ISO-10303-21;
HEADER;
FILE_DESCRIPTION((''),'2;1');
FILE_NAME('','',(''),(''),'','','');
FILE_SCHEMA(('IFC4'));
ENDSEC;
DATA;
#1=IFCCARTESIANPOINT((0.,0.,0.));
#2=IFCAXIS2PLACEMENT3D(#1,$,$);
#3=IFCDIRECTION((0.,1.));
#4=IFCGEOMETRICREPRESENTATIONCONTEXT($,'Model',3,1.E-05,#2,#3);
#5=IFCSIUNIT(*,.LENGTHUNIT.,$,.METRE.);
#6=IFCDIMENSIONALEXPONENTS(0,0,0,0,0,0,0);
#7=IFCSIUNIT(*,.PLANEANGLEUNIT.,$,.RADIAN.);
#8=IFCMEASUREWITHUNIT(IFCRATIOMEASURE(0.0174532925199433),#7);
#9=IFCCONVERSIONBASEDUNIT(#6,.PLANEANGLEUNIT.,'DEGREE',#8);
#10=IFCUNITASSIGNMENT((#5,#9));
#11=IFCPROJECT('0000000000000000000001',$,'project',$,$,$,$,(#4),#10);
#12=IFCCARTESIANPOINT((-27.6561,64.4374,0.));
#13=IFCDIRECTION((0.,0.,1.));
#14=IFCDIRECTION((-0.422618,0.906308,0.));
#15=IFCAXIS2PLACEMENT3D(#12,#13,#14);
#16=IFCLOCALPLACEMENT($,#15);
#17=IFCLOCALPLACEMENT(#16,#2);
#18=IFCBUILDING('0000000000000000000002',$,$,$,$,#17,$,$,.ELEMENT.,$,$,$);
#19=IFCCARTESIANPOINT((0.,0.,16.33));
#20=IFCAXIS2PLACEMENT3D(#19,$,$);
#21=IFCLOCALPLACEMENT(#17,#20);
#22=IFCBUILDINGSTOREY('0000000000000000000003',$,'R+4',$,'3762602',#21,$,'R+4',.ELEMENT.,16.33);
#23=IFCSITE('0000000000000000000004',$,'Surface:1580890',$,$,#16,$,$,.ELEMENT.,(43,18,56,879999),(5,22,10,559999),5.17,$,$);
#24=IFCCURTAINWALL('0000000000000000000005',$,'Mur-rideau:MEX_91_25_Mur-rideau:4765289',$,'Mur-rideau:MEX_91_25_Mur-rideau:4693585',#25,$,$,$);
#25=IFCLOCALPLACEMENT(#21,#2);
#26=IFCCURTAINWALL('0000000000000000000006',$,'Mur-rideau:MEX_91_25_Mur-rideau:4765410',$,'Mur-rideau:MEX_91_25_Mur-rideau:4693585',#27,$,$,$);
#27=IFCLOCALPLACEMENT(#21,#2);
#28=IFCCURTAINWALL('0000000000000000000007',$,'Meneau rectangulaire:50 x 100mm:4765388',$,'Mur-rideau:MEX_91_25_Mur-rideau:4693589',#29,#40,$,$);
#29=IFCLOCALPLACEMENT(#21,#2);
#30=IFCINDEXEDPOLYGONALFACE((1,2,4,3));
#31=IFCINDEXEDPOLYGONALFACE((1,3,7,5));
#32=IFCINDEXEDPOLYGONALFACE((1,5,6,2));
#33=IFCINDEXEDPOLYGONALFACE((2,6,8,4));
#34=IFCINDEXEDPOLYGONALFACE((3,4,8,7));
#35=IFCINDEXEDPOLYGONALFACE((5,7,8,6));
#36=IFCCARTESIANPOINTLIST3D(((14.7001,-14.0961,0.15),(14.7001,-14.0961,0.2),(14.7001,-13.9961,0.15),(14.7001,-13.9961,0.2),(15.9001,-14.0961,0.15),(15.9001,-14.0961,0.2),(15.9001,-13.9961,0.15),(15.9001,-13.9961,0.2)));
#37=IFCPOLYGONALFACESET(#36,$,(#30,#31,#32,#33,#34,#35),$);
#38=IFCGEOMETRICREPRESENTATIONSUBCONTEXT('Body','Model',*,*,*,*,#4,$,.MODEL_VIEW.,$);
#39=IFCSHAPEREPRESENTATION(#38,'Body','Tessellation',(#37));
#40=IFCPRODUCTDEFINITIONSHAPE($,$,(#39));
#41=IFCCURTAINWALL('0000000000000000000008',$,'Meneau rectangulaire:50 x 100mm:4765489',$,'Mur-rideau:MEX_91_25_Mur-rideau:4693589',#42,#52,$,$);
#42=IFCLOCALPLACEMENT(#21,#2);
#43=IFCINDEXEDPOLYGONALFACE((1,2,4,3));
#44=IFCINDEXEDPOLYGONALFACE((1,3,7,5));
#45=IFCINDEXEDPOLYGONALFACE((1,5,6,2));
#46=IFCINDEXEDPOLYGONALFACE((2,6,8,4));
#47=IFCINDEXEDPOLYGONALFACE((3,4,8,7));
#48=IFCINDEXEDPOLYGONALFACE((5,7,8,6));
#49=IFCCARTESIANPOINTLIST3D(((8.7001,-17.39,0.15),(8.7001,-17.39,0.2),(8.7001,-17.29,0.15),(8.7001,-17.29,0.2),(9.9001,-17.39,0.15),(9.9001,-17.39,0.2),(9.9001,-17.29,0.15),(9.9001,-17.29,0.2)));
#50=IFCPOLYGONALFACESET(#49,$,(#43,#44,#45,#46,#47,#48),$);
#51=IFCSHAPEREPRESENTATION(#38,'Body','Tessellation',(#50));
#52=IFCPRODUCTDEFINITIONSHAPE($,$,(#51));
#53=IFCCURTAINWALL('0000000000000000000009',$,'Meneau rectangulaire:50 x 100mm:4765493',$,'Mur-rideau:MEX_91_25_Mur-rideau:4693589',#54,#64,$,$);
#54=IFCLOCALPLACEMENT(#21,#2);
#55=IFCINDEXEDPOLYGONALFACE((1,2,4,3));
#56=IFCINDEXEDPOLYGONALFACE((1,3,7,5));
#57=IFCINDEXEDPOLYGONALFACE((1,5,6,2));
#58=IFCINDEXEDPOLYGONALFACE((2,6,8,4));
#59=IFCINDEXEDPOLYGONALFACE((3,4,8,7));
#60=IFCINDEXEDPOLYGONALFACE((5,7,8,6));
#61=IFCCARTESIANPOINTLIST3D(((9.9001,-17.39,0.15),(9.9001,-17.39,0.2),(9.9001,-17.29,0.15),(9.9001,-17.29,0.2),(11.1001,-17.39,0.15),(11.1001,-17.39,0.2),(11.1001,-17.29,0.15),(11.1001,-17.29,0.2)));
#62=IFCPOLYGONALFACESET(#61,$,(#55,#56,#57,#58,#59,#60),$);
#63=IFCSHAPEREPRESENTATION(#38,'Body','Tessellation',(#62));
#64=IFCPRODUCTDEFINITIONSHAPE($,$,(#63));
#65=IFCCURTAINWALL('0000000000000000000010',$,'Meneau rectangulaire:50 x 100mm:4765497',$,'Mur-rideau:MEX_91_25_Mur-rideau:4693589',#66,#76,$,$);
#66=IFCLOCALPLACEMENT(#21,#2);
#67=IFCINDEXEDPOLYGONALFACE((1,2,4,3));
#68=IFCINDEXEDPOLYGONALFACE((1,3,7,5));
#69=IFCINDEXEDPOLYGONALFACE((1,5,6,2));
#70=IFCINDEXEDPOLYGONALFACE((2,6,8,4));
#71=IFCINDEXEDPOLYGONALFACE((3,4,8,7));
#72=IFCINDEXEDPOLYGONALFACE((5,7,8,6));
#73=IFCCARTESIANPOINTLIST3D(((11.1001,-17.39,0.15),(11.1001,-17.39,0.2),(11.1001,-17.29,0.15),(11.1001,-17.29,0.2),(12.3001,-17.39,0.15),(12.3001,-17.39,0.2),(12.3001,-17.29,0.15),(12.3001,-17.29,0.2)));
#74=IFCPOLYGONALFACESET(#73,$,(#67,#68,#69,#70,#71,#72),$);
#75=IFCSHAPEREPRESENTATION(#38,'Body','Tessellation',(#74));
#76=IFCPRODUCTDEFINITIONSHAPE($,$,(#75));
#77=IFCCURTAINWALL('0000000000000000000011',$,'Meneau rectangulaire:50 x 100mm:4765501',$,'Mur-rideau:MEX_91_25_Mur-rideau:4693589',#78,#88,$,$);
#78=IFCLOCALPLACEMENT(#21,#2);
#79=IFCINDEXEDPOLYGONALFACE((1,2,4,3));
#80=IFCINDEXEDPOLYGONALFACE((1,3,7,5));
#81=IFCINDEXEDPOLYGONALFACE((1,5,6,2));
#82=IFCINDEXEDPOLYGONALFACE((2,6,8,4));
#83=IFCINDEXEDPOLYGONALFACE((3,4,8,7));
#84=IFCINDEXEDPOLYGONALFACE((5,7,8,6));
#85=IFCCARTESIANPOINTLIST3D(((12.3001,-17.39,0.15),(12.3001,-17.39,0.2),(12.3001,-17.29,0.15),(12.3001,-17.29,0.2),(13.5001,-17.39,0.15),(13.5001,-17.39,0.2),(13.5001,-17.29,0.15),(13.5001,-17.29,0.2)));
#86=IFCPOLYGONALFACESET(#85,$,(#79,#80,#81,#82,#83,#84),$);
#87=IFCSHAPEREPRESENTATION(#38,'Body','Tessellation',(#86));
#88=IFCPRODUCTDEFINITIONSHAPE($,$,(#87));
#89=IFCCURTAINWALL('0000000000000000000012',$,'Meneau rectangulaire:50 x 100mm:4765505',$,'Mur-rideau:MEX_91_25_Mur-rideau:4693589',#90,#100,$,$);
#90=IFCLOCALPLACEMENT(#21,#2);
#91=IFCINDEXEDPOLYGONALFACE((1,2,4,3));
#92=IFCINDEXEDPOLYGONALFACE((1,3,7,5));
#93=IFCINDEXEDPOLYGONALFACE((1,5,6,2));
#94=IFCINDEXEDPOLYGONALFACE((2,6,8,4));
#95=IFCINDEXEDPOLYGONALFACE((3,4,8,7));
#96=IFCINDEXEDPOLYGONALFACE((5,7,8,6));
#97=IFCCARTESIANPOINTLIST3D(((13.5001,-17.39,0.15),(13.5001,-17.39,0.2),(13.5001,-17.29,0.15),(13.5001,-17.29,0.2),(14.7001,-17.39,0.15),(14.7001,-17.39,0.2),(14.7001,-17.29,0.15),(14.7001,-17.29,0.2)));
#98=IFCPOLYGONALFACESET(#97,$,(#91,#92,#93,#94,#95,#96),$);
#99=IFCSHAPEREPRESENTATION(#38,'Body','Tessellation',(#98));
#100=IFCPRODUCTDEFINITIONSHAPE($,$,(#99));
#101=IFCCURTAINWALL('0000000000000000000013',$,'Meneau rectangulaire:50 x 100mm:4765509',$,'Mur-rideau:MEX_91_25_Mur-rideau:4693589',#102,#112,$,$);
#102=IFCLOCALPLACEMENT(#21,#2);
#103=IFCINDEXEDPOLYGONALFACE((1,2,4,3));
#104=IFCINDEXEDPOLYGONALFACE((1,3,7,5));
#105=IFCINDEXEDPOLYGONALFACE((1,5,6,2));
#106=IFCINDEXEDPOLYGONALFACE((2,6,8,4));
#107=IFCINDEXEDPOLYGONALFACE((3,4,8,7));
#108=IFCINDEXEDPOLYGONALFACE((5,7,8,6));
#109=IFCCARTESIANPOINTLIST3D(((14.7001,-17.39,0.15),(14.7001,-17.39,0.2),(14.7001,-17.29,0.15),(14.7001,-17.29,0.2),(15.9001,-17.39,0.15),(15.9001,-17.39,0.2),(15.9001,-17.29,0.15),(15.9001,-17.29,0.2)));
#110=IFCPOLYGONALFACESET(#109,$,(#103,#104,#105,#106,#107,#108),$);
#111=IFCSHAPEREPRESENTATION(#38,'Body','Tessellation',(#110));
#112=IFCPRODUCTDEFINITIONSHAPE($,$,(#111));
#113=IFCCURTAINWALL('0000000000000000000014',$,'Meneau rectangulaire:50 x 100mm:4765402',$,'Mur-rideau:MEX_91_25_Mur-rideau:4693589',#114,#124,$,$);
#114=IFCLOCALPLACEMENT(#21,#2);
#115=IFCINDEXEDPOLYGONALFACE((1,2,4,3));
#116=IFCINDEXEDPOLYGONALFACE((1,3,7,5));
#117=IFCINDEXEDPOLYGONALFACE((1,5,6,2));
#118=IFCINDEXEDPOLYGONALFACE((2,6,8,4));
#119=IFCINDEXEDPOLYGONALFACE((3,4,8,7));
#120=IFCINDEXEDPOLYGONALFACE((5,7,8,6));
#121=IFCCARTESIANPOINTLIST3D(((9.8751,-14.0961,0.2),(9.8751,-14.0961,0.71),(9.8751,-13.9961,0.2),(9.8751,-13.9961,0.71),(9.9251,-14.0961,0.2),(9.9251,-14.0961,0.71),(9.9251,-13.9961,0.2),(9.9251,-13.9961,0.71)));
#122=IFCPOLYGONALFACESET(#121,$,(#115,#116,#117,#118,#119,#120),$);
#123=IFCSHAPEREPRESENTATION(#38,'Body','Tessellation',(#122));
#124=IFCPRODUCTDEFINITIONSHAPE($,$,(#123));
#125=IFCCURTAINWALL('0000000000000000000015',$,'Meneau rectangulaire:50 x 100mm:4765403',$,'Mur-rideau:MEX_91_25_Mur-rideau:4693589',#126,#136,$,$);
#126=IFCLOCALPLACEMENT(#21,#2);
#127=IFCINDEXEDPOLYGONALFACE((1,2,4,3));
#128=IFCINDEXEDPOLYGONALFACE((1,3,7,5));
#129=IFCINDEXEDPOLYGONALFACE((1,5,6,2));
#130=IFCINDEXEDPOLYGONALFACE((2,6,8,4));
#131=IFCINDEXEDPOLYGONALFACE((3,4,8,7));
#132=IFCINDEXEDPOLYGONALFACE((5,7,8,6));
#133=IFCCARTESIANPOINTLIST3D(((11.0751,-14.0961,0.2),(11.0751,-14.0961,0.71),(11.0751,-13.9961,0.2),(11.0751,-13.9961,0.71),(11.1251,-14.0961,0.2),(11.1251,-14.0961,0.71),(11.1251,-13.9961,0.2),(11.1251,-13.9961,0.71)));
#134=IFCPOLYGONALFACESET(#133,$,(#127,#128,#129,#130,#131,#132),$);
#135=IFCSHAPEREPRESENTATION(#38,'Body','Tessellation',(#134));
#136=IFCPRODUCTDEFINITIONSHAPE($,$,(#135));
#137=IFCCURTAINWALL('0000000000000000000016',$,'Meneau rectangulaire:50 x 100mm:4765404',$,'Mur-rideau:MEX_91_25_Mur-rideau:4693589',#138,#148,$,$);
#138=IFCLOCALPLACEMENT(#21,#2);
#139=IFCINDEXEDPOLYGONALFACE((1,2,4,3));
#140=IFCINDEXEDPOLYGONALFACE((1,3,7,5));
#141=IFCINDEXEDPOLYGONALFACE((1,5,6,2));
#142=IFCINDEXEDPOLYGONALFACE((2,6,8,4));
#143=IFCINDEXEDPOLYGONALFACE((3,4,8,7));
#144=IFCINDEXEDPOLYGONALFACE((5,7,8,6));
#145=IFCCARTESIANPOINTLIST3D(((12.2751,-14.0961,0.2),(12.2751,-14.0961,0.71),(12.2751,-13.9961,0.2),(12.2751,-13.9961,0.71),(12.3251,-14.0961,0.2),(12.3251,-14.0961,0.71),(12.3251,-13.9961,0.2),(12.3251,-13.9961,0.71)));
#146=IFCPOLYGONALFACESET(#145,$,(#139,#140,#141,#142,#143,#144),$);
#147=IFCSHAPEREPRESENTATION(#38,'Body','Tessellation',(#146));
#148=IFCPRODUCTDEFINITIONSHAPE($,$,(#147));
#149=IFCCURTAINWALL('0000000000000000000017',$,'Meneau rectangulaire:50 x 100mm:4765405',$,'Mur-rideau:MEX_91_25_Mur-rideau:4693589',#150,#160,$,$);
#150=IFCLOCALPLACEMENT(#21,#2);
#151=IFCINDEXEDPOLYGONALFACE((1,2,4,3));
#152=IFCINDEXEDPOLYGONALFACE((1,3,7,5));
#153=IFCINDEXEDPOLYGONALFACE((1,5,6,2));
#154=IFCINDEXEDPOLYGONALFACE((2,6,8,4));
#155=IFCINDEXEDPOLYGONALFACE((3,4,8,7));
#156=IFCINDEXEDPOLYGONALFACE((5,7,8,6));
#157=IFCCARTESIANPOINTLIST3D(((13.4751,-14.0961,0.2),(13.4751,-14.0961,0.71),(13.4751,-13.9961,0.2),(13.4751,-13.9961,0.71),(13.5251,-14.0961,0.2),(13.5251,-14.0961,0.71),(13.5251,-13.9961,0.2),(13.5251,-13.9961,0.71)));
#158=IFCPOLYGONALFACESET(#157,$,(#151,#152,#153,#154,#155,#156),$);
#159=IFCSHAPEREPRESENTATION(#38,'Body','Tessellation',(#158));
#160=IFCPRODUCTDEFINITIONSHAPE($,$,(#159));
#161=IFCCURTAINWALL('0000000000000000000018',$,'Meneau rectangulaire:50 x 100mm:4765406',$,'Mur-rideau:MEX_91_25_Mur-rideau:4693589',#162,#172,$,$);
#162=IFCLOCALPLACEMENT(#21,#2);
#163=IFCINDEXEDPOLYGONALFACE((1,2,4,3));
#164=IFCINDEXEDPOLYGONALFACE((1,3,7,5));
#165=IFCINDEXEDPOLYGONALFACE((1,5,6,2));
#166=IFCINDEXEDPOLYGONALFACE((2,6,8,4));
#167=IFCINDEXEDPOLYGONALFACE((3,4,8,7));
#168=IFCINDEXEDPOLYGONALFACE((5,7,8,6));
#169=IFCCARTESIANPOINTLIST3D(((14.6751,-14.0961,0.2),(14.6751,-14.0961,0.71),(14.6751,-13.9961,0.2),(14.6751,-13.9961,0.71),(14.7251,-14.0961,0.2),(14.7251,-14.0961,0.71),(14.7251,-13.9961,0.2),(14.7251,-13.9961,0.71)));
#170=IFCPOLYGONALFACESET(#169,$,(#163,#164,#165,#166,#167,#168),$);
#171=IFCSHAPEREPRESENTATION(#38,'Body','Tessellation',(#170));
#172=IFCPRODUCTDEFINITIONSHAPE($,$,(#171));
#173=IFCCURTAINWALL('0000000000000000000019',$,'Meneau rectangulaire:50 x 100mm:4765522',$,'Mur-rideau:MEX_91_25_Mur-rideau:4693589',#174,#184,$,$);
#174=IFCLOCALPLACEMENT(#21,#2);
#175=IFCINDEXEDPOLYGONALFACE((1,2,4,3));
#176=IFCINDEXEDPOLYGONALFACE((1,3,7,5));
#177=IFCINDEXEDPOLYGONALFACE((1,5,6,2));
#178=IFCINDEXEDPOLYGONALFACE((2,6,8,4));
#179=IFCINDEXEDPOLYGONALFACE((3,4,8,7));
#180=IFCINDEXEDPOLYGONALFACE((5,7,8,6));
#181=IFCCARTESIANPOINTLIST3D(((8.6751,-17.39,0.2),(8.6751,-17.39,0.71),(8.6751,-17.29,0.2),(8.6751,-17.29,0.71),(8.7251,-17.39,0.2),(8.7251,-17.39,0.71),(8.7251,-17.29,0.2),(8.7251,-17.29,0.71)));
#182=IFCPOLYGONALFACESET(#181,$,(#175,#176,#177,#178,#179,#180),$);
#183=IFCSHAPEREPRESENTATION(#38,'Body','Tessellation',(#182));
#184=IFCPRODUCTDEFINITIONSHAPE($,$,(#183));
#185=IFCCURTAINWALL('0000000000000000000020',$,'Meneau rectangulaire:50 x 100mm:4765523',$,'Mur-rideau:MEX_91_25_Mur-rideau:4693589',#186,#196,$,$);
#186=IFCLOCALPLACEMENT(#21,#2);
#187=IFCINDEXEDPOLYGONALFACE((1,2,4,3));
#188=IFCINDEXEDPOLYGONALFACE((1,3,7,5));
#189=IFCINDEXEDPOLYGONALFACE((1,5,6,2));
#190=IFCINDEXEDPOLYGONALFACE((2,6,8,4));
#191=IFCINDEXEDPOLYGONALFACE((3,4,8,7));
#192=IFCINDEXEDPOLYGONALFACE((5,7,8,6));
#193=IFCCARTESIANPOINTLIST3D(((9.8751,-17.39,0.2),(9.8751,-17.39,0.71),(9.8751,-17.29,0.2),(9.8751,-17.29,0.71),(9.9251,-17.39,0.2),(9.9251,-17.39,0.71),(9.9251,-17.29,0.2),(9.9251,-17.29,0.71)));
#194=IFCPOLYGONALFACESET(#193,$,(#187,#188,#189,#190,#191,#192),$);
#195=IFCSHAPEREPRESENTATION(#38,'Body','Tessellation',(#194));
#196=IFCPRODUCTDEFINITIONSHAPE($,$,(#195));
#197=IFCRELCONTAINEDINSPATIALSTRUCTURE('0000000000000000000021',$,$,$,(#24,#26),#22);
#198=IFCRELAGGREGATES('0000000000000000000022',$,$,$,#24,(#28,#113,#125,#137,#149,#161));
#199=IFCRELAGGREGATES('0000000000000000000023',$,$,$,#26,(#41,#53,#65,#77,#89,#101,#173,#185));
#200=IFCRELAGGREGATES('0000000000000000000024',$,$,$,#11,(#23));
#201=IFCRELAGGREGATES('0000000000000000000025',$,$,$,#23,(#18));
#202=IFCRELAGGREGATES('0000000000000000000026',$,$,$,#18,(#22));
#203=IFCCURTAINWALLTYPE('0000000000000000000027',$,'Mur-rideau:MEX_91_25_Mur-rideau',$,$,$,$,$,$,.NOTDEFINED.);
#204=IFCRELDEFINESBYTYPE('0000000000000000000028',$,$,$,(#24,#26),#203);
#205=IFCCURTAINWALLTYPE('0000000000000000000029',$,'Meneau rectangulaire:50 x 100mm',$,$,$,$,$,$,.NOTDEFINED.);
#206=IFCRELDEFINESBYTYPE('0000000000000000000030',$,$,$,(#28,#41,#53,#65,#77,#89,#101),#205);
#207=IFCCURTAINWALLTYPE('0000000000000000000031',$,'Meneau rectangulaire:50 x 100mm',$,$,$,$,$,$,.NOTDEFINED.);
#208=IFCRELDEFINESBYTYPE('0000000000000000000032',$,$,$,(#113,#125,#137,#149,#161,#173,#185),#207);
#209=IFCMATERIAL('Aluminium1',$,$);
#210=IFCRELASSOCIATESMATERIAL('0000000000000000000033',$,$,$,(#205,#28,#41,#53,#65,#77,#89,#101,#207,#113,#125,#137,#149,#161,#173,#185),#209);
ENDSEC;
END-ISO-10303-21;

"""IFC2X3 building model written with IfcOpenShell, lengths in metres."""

from ifc_helpers import new_model, entity, si_unit, converted_unit, direction, frame, origin, origin_2d_with_axis, place, context, subcontext, project, spatial, rectangle, extrude, source, transform, mapped, material, type_object, type_shapes, element, aggregate, save


model = new_model("IFC2X3")

# Units and contexts
model_context = context("Model", 3, precision=1e-05, world=origin(), true_north=direction((0.0, 1.0)))
body_context = subcontext(model_context, "Body", "Model", "MODEL_VIEW")
ifc_project = project(units=[si_unit("LENGTHUNIT", "METRE"), converted_unit("PLANEANGLEUNIT", "DEGREE", entity("IfcRatioMeasure", 0.0174532925199433), si_unit("PLANEANGLEUNIT", "RADIAN"), dimensions=[0, 0, 0, 0, 0, 0, 0])], contexts=[model_context])

# Site, building, storey
site_placement = place(None, frame((-27.6561, 64.4374, 0.0), z_axis=(0.0, 0.0, 1.0), x_axis=(-0.422618, 0.906308, 0.0)))
site = spatial("IfcSite", under=ifc_project, at=site_placement, Name="Surface:1580890", CompositionType="ELEMENT", RefLatitude=(43, 18, 56, 879999), RefLongitude=(5, 22, 10, 559999), RefElevation=5.17)
building_placement = place(site_placement, origin())
building = spatial("IfcBuilding", under=site, at=building_placement, CompositionType="ELEMENT")
storey_placement = place(building_placement, frame((0.0, 0.0, 16.33)))
storey = spatial("IfcBuildingStorey", under=building, at=storey_placement, Name="R+4", ObjectType="3762602", LongName="R+4", CompositionType="ELEMENT", Elevation=16.33)

# Curtain walls
curtain_wall_type_1 = type_object("IfcCurtainWallType", Name="Mur-rideau:MEX_91_25_Mur-rideau", PredefinedType="NOTDEFINED")
curtain_wall_1_placement = place(storey_placement, frame((0.0, 0.0, -16.33)))
curtain_wall_1 = element("IfcCurtainWall", 1, at=curtain_wall_1_placement, inside=storey, type_object=curtain_wall_type_1, Name="Mur-rideau:MEX_91_25_Mur-rideau:4765289", ObjectType="Mur-rideau:MEX_91_25_Mur-rideau:4693585")
ifc_material = material(Name="Aluminium1")
placement = place(building_placement, frame((0.0, 0.0, -2.88)))
curtain_wall_2_placement = place(storey_placement, frame((0.0, 0.0, -16.33)))
curtain_wall_2 = element("IfcCurtainWall", 2, at=curtain_wall_2_placement, inside=storey, type_object=curtain_wall_type_1, Name="Mur-rideau:MEX_91_25_Mur-rideau:4765410", ObjectType="Mur-rideau:MEX_91_25_Mur-rideau:4693585")

# Curtain walls
curtain_wall_type_2 = type_object("IfcCurtainWallType", Name="Meneau rectangulaire:50 x 100mm", PredefinedType="NOTDEFINED", material=ifc_material)
shared_shape_1 = source(origin(), body_context, "Body", "SweptSolid", [
    extrude(rectangle(XDim=0.05, YDim=0.1, at=origin_2d_with_axis()), frame((-0.025, 0.0, -1.2), z_axis=(0.0, 0.0, 1.0), x_axis=(-1.0, 0.0, 0.0)), (0.0, 0.0, 1.0), 1.2),
])
type_shapes(curtain_wall_type_2, [shared_shape_1])
curtain_wall_3_placement = place(placement, frame((14.7001, -14.0461, 19.36), z_axis=(-1.0, 0.0, 0.0), x_axis=(0.0, 0.0, -1.0)))
curtain_wall_3 = element("IfcCurtainWall", 3, at=curtain_wall_3_placement, type_object=curtain_wall_type_2, material=ifc_material, Name="Meneau rectangulaire:50 x 100mm:4765388", ObjectType="Mur-rideau:MEX_91_25_Mur-rideau:4693589", context=body_context, shape_type="MappedRepresentation", body=[
    mapped(shared_shape_1, transform((0.0, 0.0, 0.0), scale=1.0)),
])
curtain_wall_4_placement = place(placement, frame((8.7001, -17.34, 19.36), z_axis=(-1.0, 0.0, 0.0), x_axis=(0.0, 0.0, -1.0)))
curtain_wall_4 = element("IfcCurtainWall", 4, at=curtain_wall_4_placement, type_object=curtain_wall_type_2, material=ifc_material, Name="Meneau rectangulaire:50 x 100mm:4765489", ObjectType="Mur-rideau:MEX_91_25_Mur-rideau:4693589", context=body_context, shape_type="MappedRepresentation", body=[
    mapped(shared_shape_1, transform((0.0, 0.0, 0.0), scale=1.0)),
])
curtain_wall_5_placement = place(placement, frame((9.9001, -17.34, 19.36), z_axis=(-1.0, 0.0, 0.0), x_axis=(0.0, 0.0, -1.0)))
curtain_wall_5 = element("IfcCurtainWall", 5, at=curtain_wall_5_placement, type_object=curtain_wall_type_2, material=ifc_material, Name="Meneau rectangulaire:50 x 100mm:4765493", ObjectType="Mur-rideau:MEX_91_25_Mur-rideau:4693589", context=body_context, shape_type="MappedRepresentation", body=[
    mapped(shared_shape_1, transform((0.0, 0.0, 0.0), scale=1.0)),
])
curtain_wall_6_placement = place(placement, frame((11.1001, -17.34, 19.36), z_axis=(-1.0, 0.0, 0.0), x_axis=(0.0, 0.0, -1.0)))
curtain_wall_6 = element("IfcCurtainWall", 6, at=curtain_wall_6_placement, type_object=curtain_wall_type_2, material=ifc_material, Name="Meneau rectangulaire:50 x 100mm:4765497", ObjectType="Mur-rideau:MEX_91_25_Mur-rideau:4693589", context=body_context, shape_type="MappedRepresentation", body=[
    mapped(shared_shape_1, transform((0.0, 0.0, 0.0), scale=1.0)),
])
curtain_wall_7_placement = place(placement, frame((12.3001, -17.34, 19.36), z_axis=(-1.0, 0.0, 0.0), x_axis=(0.0, 0.0, -1.0)))
curtain_wall_7 = element("IfcCurtainWall", 7, at=curtain_wall_7_placement, type_object=curtain_wall_type_2, material=ifc_material, Name="Meneau rectangulaire:50 x 100mm:4765501", ObjectType="Mur-rideau:MEX_91_25_Mur-rideau:4693589", context=body_context, shape_type="MappedRepresentation", body=[
    mapped(shared_shape_1, transform((0.0, 0.0, 0.0), scale=1.0)),
])
curtain_wall_8_placement = place(placement, frame((13.5001, -17.34, 19.36), z_axis=(-1.0, 0.0, 0.0), x_axis=(0.0, 0.0, -1.0)))
curtain_wall_8 = element("IfcCurtainWall", 8, at=curtain_wall_8_placement, type_object=curtain_wall_type_2, material=ifc_material, Name="Meneau rectangulaire:50 x 100mm:4765505", ObjectType="Mur-rideau:MEX_91_25_Mur-rideau:4693589", context=body_context, shape_type="MappedRepresentation", body=[
    mapped(shared_shape_1, transform((0.0, 0.0, 0.0), scale=1.0)),
])
curtain_wall_9_placement = place(placement, frame((14.7001, -17.34, 19.36), z_axis=(-1.0, 0.0, 0.0), x_axis=(0.0, 0.0, -1.0)))
curtain_wall_9 = element("IfcCurtainWall", 9, at=curtain_wall_9_placement, type_object=curtain_wall_type_2, material=ifc_material, Name="Meneau rectangulaire:50 x 100mm:4765509", ObjectType="Mur-rideau:MEX_91_25_Mur-rideau:4693589", context=body_context, shape_type="MappedRepresentation", body=[
    mapped(shared_shape_1, transform((0.0, 0.0, 0.0), scale=1.0)),
])
curtain_wall_type_3 = type_object("IfcCurtainWallType", Name="Meneau rectangulaire:50 x 100mm", PredefinedType="NOTDEFINED", material=ifc_material)
shared_shape_2 = source(origin(), body_context, "Body", "SweptSolid", [
    extrude(rectangle(XDim=0.05, YDim=0.1, at=origin_2d_with_axis()), frame((0.0, 0.0, -0.51), z_axis=(0.0, 0.0, 1.0), x_axis=(-1.0, 0.0, 0.0)), (0.0, 0.0, 1.0), 0.51),
])
type_shapes(curtain_wall_type_3, [shared_shape_2])
curtain_wall_10_placement = place(placement, frame((9.9001, -14.0461, 19.41), z_axis=(0.0, 0.0, -1.0), x_axis=(1.0, 0.0, 0.0)))
curtain_wall_10 = element("IfcCurtainWall", 10, at=curtain_wall_10_placement, type_object=curtain_wall_type_3, material=ifc_material, Name="Meneau rectangulaire:50 x 100mm:4765402", ObjectType="Mur-rideau:MEX_91_25_Mur-rideau:4693589", context=body_context, shape_type="MappedRepresentation", body=[
    mapped(shared_shape_2, transform((0.0, 0.0, 0.0), scale=1.0)),
])
curtain_wall_11_placement = place(placement, frame((11.1001, -14.0461, 19.41), z_axis=(0.0, 0.0, -1.0), x_axis=(1.0, 0.0, 0.0)))
curtain_wall_11 = element("IfcCurtainWall", 11, at=curtain_wall_11_placement, type_object=curtain_wall_type_3, material=ifc_material, Name="Meneau rectangulaire:50 x 100mm:4765403", ObjectType="Mur-rideau:MEX_91_25_Mur-rideau:4693589", context=body_context, shape_type="MappedRepresentation", body=[
    mapped(shared_shape_2, transform((0.0, 0.0, 0.0), scale=1.0)),
])
curtain_wall_12_placement = place(placement, frame((12.3001, -14.0461, 19.41), z_axis=(0.0, 0.0, -1.0), x_axis=(1.0, 0.0, 0.0)))
curtain_wall_12 = element("IfcCurtainWall", 12, at=curtain_wall_12_placement, type_object=curtain_wall_type_3, material=ifc_material, Name="Meneau rectangulaire:50 x 100mm:4765404", ObjectType="Mur-rideau:MEX_91_25_Mur-rideau:4693589", context=body_context, shape_type="MappedRepresentation", body=[
    mapped(shared_shape_2, transform((0.0, 0.0, 0.0), scale=1.0)),
])
curtain_wall_13_placement = place(placement, frame((13.5001, -14.0461, 19.41), z_axis=(0.0, 0.0, -1.0), x_axis=(1.0, 0.0, 0.0)))
curtain_wall_13 = element("IfcCurtainWall", 13, at=curtain_wall_13_placement, type_object=curtain_wall_type_3, material=ifc_material, Name="Meneau rectangulaire:50 x 100mm:4765405", ObjectType="Mur-rideau:MEX_91_25_Mur-rideau:4693589", context=body_context, shape_type="MappedRepresentation", body=[
    mapped(shared_shape_2, transform((0.0, 0.0, 0.0), scale=1.0)),
])
curtain_wall_14_placement = place(placement, frame((14.7001, -14.0461, 19.41), z_axis=(0.0, 0.0, -1.0), x_axis=(1.0, 0.0, 0.0)))
curtain_wall_14 = element("IfcCurtainWall", 14, at=curtain_wall_14_placement, type_object=curtain_wall_type_3, material=ifc_material, Name="Meneau rectangulaire:50 x 100mm:4765406", ObjectType="Mur-rideau:MEX_91_25_Mur-rideau:4693589", context=body_context, shape_type="MappedRepresentation", body=[
    mapped(shared_shape_2, transform((0.0, 0.0, 0.0), scale=1.0)),
])
aggregate(curtain_wall_1, [curtain_wall_3, curtain_wall_10, curtain_wall_11, curtain_wall_12, curtain_wall_13, curtain_wall_14])
curtain_wall_15_placement = place(placement, frame((8.7001, -17.34, 19.41), z_axis=(0.0, 0.0, -1.0), x_axis=(1.0, 0.0, 0.0)))
curtain_wall_15 = element("IfcCurtainWall", 15, at=curtain_wall_15_placement, type_object=curtain_wall_type_3, material=ifc_material, Name="Meneau rectangulaire:50 x 100mm:4765522", ObjectType="Mur-rideau:MEX_91_25_Mur-rideau:4693589", context=body_context, shape_type="MappedRepresentation", body=[
    mapped(shared_shape_2, transform((0.0, 0.0, 0.0), scale=1.0)),
])
curtain_wall_16_placement = place(placement, frame((9.9001, -17.34, 19.41), z_axis=(0.0, 0.0, -1.0), x_axis=(1.0, 0.0, 0.0)))
curtain_wall_16 = element("IfcCurtainWall", 16, at=curtain_wall_16_placement, type_object=curtain_wall_type_3, material=ifc_material, Name="Meneau rectangulaire:50 x 100mm:4765523", ObjectType="Mur-rideau:MEX_91_25_Mur-rideau:4693589", context=body_context, shape_type="MappedRepresentation", body=[
    mapped(shared_shape_2, transform((0.0, 0.0, 0.0), scale=1.0)),
])
aggregate(curtain_wall_2, [curtain_wall_4, curtain_wall_5, curtain_wall_6, curtain_wall_7, curtain_wall_8, curtain_wall_9, curtain_wall_15, curtain_wall_16])

save(model, "model.ifc")
